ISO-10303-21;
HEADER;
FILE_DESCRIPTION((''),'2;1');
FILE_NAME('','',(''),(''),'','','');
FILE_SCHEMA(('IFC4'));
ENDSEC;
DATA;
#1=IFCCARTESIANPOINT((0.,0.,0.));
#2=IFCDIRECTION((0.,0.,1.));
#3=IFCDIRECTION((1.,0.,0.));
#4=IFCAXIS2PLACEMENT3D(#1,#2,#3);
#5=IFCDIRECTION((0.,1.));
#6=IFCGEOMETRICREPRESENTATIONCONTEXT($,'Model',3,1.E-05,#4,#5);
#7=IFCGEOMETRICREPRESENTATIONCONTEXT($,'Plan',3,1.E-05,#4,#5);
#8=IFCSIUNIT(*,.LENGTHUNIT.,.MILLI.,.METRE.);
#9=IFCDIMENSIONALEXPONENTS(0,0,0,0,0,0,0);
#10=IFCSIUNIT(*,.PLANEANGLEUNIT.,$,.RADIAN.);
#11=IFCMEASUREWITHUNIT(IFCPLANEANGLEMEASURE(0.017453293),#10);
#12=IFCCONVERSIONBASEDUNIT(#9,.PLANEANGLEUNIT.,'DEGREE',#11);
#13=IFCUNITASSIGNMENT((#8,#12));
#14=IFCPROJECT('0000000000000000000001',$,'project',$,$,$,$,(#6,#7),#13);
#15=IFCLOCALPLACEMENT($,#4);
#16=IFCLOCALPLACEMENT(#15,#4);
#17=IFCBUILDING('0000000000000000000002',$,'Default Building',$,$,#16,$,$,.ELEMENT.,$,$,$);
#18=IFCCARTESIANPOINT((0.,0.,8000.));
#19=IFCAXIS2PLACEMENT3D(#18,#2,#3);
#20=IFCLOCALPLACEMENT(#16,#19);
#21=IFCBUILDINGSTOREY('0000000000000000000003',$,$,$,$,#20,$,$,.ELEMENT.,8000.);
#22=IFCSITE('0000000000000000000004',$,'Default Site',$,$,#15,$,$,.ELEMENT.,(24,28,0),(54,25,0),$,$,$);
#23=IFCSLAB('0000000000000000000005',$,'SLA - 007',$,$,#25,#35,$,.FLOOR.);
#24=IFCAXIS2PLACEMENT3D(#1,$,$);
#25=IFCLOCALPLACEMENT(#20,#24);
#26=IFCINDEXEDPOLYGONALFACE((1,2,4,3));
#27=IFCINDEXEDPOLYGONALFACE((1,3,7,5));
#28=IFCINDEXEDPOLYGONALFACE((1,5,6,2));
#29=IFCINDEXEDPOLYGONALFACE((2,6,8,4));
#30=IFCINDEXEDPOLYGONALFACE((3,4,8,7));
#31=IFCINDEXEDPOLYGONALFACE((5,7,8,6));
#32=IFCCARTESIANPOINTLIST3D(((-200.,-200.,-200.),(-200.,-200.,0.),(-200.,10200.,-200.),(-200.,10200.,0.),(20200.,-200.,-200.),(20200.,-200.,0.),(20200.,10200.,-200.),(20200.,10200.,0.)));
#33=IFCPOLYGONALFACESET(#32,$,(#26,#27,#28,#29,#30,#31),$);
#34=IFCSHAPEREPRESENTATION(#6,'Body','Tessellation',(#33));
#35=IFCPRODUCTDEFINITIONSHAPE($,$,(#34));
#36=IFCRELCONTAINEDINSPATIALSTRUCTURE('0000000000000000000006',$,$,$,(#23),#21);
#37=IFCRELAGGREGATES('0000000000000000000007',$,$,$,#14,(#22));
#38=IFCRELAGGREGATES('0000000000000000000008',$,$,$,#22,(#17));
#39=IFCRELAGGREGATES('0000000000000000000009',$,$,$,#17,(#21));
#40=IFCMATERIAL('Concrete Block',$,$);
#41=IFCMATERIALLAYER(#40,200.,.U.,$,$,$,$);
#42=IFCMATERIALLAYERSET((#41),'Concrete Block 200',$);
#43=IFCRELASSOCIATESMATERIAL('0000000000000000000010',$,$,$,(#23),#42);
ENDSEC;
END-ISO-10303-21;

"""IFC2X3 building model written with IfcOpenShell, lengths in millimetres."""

from ifc_helpers import new_model, entity, si_unit, converted_unit, direction, frame, origin_with_axes, place, context, project, spatial, polyline, outline, extrude, material, layer, layer_set, layer_usage, element, save


model = new_model("IFC2X3")

# Units and contexts
model_context = context("Model", 3, precision=1e-05, world=origin_with_axes(), true_north=direction((0.0, 1.0)))
plan_context = context("Plan", 3, precision=1e-05, world=origin_with_axes(), true_north=direction((0.0, 1.0)))
ifc_project = project(units=[si_unit("LENGTHUNIT", "METRE", prefix="MILLI"), converted_unit("PLANEANGLEUNIT", "DEGREE", entity("IfcPlaneAngleMeasure", 0.017453293), si_unit("PLANEANGLEUNIT", "RADIAN"), dimensions=[0, 0, 0, 0, 0, 0, 0])], contexts=[model_context, plan_context])

# Site, building, storey
site_placement = place(None, origin_with_axes())
site = spatial("IfcSite", under=ifc_project, at=site_placement, Name="Default Site", CompositionType="ELEMENT", RefLatitude=(24, 28, 0), RefLongitude=(54, 25, 0))
building_placement = place(site_placement, origin_with_axes())
building = spatial("IfcBuilding", under=site, at=building_placement, Name="Default Building", CompositionType="ELEMENT")
storey_placement = place(building_placement, frame((0.0, 0.0, 8000.0), z_axis=(0.0, 0.0, 1.0), x_axis=(1.0, 0.0, 0.0)))
storey = spatial("IfcBuildingStorey", under=building, at=storey_placement, CompositionType="ELEMENT", Elevation=8000.0)

# Slab
ifc_material = material(Name="Concrete Block")
ifc_layer = layer(ifc_material, 200.0, ventilated="UNKNOWN")
ifc_layer_set = layer_set([ifc_layer], Name="Concrete Block 200")
ifc_layer_usage = layer_usage(ifc_layer_set, "AXIS3", "NEGATIVE", 200.0)
slab_placement = place(storey_placement, frame((-200.0, 10200.0, -200.0), z_axis=(0.0, 0.0, 1.0), x_axis=(1.0, 0.0, 0.0)))
element("IfcSlab", 1, at=slab_placement, inside=storey, material=ifc_layer_usage, Name="SLA - 007", PredefinedType="FLOOR", context=model_context, shape_type="SweptSolid", body=[
    extrude(outline(polyline([(0.0, 0.0), (20400.0, 0.0), (20400.0, -10400.0), (0.0, -10400.0), (0.0, 0.0)])), origin_with_axes(), (0.0, 0.0, 1.0), 200.0),
])

save(model, "model.ifc")
